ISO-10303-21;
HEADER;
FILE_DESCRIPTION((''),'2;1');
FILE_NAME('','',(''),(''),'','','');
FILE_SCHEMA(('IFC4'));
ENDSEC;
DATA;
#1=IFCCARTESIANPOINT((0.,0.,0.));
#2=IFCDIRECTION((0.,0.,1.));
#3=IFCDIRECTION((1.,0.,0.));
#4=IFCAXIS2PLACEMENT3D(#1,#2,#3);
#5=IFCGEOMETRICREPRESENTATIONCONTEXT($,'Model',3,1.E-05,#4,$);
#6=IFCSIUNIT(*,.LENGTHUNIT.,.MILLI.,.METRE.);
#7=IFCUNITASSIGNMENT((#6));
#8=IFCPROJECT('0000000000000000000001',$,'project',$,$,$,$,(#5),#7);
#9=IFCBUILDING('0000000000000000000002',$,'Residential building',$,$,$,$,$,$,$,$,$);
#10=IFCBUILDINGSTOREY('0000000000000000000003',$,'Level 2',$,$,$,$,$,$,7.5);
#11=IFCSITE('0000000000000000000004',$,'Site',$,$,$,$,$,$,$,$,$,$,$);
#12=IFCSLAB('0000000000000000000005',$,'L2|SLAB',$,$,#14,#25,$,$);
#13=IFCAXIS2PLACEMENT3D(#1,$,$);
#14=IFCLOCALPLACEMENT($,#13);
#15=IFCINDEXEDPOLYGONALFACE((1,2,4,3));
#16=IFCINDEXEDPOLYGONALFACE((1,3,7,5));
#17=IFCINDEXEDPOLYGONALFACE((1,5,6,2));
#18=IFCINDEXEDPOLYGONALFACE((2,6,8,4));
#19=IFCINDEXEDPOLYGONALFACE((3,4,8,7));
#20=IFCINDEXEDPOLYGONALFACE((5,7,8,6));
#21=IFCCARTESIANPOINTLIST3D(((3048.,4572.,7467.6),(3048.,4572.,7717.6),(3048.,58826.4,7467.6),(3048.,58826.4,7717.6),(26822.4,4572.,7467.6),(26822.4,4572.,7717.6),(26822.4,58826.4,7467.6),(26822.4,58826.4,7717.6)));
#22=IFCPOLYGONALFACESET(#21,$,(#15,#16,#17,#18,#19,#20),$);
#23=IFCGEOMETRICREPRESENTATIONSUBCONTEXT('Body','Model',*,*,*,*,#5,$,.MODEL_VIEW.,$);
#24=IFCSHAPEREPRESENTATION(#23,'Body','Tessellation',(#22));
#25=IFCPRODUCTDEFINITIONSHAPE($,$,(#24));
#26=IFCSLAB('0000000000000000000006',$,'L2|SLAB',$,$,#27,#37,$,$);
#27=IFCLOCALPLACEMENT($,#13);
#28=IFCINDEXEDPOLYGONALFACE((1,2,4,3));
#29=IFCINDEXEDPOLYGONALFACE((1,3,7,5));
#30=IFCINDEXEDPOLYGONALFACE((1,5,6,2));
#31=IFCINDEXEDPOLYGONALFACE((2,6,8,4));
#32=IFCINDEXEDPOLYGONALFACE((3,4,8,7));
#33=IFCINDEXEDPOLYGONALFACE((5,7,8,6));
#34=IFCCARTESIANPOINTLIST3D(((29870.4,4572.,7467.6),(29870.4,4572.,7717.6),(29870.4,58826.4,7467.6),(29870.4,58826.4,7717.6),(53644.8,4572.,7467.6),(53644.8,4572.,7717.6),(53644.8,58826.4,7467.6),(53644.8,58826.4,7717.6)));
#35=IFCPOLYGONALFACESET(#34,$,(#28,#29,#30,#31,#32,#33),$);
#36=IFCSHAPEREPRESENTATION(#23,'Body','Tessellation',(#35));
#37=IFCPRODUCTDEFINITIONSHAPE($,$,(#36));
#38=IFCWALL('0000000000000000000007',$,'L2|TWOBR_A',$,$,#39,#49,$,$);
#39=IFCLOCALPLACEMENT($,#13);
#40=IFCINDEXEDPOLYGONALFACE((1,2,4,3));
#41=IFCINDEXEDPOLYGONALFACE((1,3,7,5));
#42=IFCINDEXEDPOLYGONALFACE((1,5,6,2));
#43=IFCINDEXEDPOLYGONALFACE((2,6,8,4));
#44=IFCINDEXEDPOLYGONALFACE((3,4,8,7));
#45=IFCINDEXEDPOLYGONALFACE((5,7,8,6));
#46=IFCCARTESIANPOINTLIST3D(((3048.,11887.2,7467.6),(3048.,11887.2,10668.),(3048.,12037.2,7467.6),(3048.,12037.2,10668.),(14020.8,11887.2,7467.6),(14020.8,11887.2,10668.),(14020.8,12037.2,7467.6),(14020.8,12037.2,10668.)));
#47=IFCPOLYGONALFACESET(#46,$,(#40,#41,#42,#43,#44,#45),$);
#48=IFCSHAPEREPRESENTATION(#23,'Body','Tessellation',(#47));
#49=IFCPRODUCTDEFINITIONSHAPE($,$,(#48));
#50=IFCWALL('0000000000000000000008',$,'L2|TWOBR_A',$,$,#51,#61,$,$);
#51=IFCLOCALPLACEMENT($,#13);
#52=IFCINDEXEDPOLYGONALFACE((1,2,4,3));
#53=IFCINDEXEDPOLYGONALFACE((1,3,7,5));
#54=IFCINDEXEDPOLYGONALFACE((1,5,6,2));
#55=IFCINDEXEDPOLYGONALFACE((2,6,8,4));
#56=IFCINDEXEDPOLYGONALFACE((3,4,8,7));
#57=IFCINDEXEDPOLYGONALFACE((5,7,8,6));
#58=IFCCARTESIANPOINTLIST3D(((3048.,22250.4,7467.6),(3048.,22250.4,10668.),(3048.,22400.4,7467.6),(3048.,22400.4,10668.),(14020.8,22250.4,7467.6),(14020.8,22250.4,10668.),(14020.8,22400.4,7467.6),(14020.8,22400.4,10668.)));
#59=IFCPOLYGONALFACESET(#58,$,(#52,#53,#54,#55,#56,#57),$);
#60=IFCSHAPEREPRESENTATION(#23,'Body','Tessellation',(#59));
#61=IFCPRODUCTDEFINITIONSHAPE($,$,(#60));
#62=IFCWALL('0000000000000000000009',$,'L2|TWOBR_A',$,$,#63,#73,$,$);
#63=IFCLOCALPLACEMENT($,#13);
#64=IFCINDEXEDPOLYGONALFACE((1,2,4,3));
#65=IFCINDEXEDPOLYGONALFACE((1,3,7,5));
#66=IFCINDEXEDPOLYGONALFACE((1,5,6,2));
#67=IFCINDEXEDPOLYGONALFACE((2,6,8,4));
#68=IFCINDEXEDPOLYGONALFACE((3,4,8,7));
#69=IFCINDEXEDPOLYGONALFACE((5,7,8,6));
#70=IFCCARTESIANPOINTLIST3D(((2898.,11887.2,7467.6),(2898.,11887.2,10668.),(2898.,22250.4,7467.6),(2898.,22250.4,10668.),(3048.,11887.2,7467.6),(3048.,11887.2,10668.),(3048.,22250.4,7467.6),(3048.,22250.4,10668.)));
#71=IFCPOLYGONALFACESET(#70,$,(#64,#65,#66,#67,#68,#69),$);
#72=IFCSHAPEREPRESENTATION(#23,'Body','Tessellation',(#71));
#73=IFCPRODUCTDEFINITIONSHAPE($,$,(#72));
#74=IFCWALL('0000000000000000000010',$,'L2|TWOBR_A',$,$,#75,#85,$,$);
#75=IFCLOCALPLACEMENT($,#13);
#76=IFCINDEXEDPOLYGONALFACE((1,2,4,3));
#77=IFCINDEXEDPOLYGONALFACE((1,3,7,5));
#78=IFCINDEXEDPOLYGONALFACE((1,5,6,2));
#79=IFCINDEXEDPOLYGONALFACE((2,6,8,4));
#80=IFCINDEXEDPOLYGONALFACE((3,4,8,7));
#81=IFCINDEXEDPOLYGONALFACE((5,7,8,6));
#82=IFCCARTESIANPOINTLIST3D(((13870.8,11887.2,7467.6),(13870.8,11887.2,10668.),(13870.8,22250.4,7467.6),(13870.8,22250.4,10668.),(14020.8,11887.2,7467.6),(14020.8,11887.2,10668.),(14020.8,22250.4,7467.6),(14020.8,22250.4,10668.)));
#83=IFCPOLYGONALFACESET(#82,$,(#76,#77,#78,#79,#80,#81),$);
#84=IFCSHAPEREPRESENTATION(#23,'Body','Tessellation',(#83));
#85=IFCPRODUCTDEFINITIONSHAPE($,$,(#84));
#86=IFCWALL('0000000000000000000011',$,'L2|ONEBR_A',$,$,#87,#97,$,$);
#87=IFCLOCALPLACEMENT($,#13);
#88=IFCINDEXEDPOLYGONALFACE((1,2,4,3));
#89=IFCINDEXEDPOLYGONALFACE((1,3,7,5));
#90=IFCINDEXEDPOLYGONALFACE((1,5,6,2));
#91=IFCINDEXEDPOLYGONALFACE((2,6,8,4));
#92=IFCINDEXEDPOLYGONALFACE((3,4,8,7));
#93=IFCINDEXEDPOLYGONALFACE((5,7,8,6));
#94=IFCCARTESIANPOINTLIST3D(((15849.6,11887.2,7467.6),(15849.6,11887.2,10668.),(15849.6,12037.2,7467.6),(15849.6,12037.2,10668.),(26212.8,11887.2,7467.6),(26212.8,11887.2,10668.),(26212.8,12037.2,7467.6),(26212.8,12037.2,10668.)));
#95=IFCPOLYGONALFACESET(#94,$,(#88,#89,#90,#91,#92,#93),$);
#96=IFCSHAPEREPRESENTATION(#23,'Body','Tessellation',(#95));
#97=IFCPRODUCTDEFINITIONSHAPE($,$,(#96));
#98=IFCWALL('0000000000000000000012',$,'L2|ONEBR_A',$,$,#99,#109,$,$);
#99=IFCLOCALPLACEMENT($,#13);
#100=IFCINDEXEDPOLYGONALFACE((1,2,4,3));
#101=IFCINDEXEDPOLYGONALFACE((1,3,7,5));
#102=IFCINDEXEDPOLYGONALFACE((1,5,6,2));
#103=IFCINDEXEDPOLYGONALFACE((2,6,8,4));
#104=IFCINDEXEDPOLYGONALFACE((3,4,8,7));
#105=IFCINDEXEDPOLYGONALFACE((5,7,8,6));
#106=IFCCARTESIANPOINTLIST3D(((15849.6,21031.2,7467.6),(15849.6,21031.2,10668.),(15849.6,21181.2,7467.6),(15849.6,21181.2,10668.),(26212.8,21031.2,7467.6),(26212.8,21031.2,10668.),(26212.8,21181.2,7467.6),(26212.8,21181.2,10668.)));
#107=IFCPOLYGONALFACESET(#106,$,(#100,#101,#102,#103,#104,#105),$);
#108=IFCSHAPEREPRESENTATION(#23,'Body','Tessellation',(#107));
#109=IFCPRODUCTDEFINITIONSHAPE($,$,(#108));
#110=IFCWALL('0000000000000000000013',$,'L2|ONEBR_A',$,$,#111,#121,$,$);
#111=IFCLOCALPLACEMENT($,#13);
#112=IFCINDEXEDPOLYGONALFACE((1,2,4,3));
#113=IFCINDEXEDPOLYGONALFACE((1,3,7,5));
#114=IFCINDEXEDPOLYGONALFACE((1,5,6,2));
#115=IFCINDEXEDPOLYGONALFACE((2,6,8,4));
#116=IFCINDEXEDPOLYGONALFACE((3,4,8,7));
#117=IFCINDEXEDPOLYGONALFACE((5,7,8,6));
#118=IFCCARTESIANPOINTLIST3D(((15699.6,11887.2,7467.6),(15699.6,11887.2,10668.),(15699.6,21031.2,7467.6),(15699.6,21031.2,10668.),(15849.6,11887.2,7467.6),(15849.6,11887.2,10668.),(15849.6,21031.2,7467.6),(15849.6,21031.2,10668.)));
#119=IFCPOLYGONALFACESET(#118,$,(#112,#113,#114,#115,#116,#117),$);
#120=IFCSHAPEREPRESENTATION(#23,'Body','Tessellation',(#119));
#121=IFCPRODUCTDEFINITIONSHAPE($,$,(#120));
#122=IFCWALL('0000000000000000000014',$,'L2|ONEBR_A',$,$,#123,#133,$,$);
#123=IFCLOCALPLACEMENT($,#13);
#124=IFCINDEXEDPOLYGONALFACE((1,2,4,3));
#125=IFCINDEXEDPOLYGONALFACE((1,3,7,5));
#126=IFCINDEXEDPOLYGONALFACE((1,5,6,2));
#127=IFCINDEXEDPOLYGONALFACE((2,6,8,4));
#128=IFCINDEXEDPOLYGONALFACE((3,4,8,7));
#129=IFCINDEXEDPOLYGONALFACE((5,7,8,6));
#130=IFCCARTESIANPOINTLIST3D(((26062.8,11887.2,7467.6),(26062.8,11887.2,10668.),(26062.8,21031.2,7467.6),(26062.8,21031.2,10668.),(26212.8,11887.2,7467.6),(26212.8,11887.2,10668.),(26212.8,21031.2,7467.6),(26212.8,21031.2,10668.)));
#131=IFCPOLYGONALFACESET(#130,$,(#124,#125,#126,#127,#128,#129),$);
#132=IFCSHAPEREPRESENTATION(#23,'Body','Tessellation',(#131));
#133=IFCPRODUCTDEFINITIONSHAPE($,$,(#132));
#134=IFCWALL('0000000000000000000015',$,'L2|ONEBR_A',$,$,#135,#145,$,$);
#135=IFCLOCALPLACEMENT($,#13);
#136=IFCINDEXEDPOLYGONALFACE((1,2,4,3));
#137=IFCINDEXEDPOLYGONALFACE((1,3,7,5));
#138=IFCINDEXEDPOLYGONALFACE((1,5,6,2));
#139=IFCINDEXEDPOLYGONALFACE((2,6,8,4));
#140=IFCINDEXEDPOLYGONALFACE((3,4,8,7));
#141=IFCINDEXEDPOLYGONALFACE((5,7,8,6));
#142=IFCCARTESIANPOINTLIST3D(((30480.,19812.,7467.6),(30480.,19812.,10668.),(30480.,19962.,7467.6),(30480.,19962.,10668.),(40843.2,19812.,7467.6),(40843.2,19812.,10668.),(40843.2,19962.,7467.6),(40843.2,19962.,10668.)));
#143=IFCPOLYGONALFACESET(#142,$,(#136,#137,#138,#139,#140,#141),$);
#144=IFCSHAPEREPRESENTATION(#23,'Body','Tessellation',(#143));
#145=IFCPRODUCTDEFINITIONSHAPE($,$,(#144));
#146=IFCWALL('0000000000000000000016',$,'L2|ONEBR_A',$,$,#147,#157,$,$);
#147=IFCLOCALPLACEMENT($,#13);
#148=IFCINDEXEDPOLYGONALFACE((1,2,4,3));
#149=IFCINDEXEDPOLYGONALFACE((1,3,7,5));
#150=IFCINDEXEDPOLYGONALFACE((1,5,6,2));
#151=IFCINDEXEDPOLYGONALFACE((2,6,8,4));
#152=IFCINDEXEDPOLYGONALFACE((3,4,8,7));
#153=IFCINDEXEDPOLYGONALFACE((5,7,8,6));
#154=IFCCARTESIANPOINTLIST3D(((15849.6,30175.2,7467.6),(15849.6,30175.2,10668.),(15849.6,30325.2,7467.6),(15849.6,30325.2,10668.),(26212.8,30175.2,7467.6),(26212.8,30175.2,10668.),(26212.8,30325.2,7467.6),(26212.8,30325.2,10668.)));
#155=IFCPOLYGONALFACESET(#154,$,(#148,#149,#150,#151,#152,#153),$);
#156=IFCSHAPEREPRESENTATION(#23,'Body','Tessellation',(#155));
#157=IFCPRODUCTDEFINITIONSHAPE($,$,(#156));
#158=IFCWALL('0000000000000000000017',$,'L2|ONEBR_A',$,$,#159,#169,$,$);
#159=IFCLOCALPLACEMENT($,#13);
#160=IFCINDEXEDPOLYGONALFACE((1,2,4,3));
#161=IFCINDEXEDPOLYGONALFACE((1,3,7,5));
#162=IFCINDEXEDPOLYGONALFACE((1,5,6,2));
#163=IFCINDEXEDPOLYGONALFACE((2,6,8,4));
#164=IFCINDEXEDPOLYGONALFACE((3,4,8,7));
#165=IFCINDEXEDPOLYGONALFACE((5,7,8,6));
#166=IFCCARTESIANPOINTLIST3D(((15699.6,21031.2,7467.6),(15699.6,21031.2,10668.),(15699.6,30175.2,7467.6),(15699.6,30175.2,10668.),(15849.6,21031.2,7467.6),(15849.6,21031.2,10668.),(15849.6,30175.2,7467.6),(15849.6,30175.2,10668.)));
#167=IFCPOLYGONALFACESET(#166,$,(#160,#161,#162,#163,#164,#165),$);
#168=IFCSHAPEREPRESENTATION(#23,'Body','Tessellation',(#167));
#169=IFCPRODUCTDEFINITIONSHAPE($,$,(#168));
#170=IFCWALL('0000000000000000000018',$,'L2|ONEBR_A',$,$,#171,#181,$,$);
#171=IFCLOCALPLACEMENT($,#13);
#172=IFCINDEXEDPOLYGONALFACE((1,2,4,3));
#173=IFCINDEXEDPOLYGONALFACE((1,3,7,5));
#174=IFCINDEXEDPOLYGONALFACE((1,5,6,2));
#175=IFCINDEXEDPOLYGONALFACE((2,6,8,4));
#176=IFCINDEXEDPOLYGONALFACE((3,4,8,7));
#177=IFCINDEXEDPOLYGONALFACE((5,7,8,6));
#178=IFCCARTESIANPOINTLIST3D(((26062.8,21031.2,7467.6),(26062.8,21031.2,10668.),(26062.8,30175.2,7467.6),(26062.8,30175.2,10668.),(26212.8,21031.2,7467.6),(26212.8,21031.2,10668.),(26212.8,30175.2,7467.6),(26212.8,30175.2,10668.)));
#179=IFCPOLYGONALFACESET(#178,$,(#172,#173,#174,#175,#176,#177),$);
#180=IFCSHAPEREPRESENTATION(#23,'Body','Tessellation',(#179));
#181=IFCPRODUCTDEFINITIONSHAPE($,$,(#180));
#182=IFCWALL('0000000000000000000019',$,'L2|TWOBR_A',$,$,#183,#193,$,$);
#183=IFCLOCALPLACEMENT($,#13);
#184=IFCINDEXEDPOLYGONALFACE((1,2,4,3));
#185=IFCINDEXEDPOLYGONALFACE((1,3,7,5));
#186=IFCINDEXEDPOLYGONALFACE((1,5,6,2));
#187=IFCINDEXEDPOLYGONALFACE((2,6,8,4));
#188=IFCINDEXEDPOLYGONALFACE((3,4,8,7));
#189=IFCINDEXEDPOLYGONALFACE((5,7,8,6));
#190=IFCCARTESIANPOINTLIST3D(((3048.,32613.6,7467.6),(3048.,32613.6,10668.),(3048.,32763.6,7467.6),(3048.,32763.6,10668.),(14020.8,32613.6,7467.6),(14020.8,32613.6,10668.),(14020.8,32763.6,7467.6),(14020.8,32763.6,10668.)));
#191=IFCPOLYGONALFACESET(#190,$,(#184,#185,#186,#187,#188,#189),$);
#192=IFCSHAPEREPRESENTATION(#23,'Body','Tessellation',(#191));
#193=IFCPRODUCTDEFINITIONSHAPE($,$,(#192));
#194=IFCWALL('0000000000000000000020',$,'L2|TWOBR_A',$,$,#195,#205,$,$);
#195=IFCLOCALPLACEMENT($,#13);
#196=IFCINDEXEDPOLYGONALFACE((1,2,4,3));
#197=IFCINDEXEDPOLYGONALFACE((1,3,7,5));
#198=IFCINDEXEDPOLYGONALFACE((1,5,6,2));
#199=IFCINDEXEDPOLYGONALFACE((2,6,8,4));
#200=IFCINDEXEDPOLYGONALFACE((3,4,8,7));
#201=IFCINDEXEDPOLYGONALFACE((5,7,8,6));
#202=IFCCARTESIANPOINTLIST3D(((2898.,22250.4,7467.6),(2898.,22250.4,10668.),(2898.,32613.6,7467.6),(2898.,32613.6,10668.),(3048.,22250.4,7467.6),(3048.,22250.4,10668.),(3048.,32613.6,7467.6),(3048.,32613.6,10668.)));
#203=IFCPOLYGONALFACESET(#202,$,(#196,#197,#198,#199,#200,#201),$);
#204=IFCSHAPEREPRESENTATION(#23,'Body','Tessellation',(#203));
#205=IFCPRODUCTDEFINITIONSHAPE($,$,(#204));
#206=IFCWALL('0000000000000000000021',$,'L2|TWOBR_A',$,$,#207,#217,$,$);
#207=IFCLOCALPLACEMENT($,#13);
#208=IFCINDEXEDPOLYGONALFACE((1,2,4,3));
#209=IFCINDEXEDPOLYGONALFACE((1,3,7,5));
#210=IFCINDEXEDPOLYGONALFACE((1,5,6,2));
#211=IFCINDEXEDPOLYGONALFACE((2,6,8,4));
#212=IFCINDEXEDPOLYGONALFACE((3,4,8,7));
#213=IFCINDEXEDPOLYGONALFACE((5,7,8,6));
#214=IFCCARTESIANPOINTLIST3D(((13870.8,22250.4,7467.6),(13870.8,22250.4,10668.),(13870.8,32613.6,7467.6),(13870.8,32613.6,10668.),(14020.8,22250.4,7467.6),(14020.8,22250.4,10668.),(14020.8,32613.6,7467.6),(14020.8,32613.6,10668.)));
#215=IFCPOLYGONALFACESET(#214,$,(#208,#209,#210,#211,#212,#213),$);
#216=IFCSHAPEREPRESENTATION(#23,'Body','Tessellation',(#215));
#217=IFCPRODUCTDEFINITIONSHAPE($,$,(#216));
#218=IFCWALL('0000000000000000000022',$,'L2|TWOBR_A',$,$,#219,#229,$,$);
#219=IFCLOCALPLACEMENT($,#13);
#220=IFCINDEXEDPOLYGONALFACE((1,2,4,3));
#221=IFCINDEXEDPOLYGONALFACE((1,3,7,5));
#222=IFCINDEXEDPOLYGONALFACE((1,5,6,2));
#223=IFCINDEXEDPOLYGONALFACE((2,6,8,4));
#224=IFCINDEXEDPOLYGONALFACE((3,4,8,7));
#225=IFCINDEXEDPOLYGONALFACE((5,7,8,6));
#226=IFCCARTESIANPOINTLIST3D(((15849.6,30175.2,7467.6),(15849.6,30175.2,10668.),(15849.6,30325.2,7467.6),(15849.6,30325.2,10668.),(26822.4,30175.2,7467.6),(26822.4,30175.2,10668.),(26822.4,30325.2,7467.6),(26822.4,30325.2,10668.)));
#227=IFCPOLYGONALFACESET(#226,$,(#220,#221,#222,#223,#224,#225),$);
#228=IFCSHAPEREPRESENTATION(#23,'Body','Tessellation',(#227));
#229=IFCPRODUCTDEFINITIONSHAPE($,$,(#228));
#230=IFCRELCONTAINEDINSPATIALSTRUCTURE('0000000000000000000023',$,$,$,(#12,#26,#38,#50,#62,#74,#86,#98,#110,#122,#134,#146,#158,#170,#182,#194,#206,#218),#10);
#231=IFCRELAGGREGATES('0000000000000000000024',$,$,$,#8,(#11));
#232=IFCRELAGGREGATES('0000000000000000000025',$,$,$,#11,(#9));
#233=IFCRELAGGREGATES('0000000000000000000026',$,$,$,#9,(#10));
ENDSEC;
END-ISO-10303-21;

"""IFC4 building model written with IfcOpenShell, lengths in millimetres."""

from ifc_helpers import new_model, si_unit, frame, origin_with_axes, place, context, subcontext, project, spatial, indexed_curve, outline, extrude, element, save


model = new_model("IFC4")

# Units and contexts
model_context = context("Model", 3, precision=1e-05, world=origin_with_axes())
body_context = subcontext(model_context, "Body", "Model", "MODEL_VIEW")
ifc_project = project(units=[si_unit("LENGTHUNIT", "METRE", prefix="MILLI")], contexts=[model_context])

# Site, building, storey
site = spatial("IfcSite", under=ifc_project, Name="Site")
building = spatial("IfcBuilding", under=site, Name="Residential building")
storey = spatial("IfcBuildingStorey", under=building, Name="Level 2", Elevation=7.5)

# Slabs
for number, where, z_axis, x_axis, name in (
    (1, (3048.0, 4572.0, 7467.6), (0.0, 0.0, 1.0), (1.0, 0.0, 0.0), "L2|SLAB"),
    (2, (29870.4, 4572.0, 7467.6), (0.0, 0.0, 1.0), (1.0, 0.0, 0.0), "L2|SLAB"),
):
    element("IfcSlab", number, at=place(None, frame(where, z_axis=z_axis, x_axis=x_axis)), inside=storey, Name=name, context=body_context, shape_type="SweptSolid", body=[
        extrude(outline(indexed_curve([(0.0, 0.0), (23774.4, 0.0), (23774.4, 54254.4), (0.0, 54254.4), (0.0, 0.0)])), None, (0.0, 0.0, 1.0), 250.0),
    ])

# Walls
for number, where, z_axis, x_axis, name in (
    (3, (3048.0, 11887.2, 7467.6), (0.0, 0.0, 1.0), (1.0, 0.0, 0.0), "L2|TWOBR_A"),
    (4, (3048.0, 22250.4, 7467.6), (0.0, 0.0, 1.0), (1.0, 0.0, 0.0), "L2|TWOBR_A"),
):
    element("IfcWall", number, at=place(None, frame(where, z_axis=z_axis, x_axis=x_axis)), inside=storey, Name=name, context=body_context, shape_type="SweptSolid", body=[
        extrude(outline(indexed_curve([(0.0, 0.0), (0.0, 150.0), (10972.8, 150.0), (10972.8, 0.0), (0.0, 0.0)], self_intersect=False)), origin_with_axes(), (0.0, 0.0, 1.0), 3200.4),
    ])
for number, where, z_axis, x_axis, name in (
    (5, (3048.0, 11887.2, 7467.6), (0.0, 0.0, 1.0), (0.0, 1.0, 0.0), "L2|TWOBR_A"),
    (6, (14020.8, 11887.2, 7467.6), (0.0, 0.0, 1.0), (0.0, 1.0, 0.0), "L2|TWOBR_A"),
    (7, (15849.6, 11887.2, 7467.6), (0.0, 0.0, 1.0), (1.0, 0.0, 0.0), "L2|ONEBR_A"),
    (8, (15849.6, 21031.2, 7467.6), (0.0, 0.0, 1.0), (1.0, 0.0, 0.0), "L2|ONEBR_A"),
):
    element("IfcWall", number, at=place(None, frame(where, z_axis=z_axis, x_axis=x_axis)), inside=storey, Name=name, context=body_context, shape_type="SweptSolid", body=[
        extrude(outline(indexed_curve([(0.0, 0.0), (0.0, 150.0), (10363.2, 150.0), (10363.2, 0.0), (0.0, 0.0)], self_intersect=False)), origin_with_axes(), (0.0, 0.0, 1.0), 3200.4),
    ])
for number, where, z_axis, x_axis, name in (
    (9, (15849.6, 11887.2, 7467.6), (0.0, 0.0, 1.0), (0.0, 1.0, 0.0), "L2|ONEBR_A"),
    (10, (26212.8, 11887.2, 7467.6), (0.0, 0.0, 1.0), (0.0, 1.0, 0.0), "L2|ONEBR_A"),
):
    element("IfcWall", number, at=place(None, frame(where, z_axis=z_axis, x_axis=x_axis)), inside=storey, Name=name, context=body_context, shape_type="SweptSolid", body=[
        extrude(outline(indexed_curve([(0.0, 0.0), (0.0, 150.0), (9144.0, 150.0), (9144.0, 0.0), (0.0, 0.0)], self_intersect=False)), origin_with_axes(), (0.0, 0.0, 1.0), 3200.4),
    ])
for number, where, z_axis, x_axis, name in (
    (11, (30480.0, 19812.0, 7467.6), (0.0, 0.0, 1.0), (1.0, 0.0, 0.0), "L2|ONEBR_A"),
    (12, (15849.6, 30175.2, 7467.6), (0.0, 0.0, 1.0), (1.0, 0.0, 0.0), "L2|ONEBR_A"),
):
    element("IfcWall", number, at=place(None, frame(where, z_axis=z_axis, x_axis=x_axis)), inside=storey, Name=name, context=body_context, shape_type="SweptSolid", body=[
        extrude(outline(indexed_curve([(0.0, 0.0), (0.0, 150.0), (10363.2, 150.0), (10363.2, 0.0), (0.0, 0.0)], self_intersect=False)), origin_with_axes(), (0.0, 0.0, 1.0), 3200.4),
    ])
for number, where, z_axis, x_axis, name in (
    (13, (15849.6, 21031.2, 7467.6), (0.0, 0.0, 1.0), (0.0, 1.0, 0.0), "L2|ONEBR_A"),
    (14, (26212.8, 21031.2, 7467.6), (0.0, 0.0, 1.0), (0.0, 1.0, 0.0), "L2|ONEBR_A"),
):
    element("IfcWall", number, at=place(None, frame(where, z_axis=z_axis, x_axis=x_axis)), inside=storey, Name=name, context=body_context, shape_type="SweptSolid", body=[
        extrude(outline(indexed_curve([(0.0, 0.0), (0.0, 150.0), (9144.0, 150.0), (9144.0, 0.0), (0.0, 0.0)], self_intersect=False)), origin_with_axes(), (0.0, 0.0, 1.0), 3200.4),
    ])
for number, where, z_axis, x_axis, name in (
    (15, (3048.0, 32613.6, 7467.6), (0.0, 0.0, 1.0), (1.0, 0.0, 0.0), "L2|TWOBR_A"),
):
    element("IfcWall", number, at=place(None, frame(where, z_axis=z_axis, x_axis=x_axis)), inside=storey, Name=name, context=body_context, shape_type="SweptSolid", body=[
        extrude(outline(indexed_curve([(0.0, 0.0), (0.0, 150.0), (10972.8, 150.0), (10972.8, 0.0), (0.0, 0.0)], self_intersect=False)), origin_with_axes(), (0.0, 0.0, 1.0), 3200.4),
    ])
for number, where, z_axis, x_axis, name in (
    (16, (3048.0, 22250.4, 7467.6), (0.0, 0.0, 1.0), (0.0, 1.0, 0.0), "L2|TWOBR_A"),
    (17, (14020.8, 22250.4, 7467.6), (0.0, 0.0, 1.0), (0.0, 1.0, 0.0), "L2|TWOBR_A"),
):
    element("IfcWall", number, at=place(None, frame(where, z_axis=z_axis, x_axis=x_axis)), inside=storey, Name=name, context=body_context, shape_type="SweptSolid", body=[
        extrude(outline(indexed_curve([(0.0, 0.0), (0.0, 150.0), (10363.2, 150.0), (10363.2, 0.0), (0.0, 0.0)], self_intersect=False)), origin_with_axes(), (0.0, 0.0, 1.0), 3200.4),
    ])
for number, where, z_axis, x_axis, name in (
    (18, (15849.6, 30175.2, 7467.6), (0.0, 0.0, 1.0), (1.0, 0.0, 0.0), "L2|TWOBR_A"),
):
    element("IfcWall", number, at=place(None, frame(where, z_axis=z_axis, x_axis=x_axis)), inside=storey, Name=name, context=body_context, shape_type="SweptSolid", body=[
        extrude(outline(indexed_curve([(0.0, 0.0), (0.0, 150.0), (10972.8, 150.0), (10972.8, 0.0), (0.0, 0.0)], self_intersect=False)), origin_with_axes(), (0.0, 0.0, 1.0), 3200.4),
    ])

save(model, "model.ifc")
